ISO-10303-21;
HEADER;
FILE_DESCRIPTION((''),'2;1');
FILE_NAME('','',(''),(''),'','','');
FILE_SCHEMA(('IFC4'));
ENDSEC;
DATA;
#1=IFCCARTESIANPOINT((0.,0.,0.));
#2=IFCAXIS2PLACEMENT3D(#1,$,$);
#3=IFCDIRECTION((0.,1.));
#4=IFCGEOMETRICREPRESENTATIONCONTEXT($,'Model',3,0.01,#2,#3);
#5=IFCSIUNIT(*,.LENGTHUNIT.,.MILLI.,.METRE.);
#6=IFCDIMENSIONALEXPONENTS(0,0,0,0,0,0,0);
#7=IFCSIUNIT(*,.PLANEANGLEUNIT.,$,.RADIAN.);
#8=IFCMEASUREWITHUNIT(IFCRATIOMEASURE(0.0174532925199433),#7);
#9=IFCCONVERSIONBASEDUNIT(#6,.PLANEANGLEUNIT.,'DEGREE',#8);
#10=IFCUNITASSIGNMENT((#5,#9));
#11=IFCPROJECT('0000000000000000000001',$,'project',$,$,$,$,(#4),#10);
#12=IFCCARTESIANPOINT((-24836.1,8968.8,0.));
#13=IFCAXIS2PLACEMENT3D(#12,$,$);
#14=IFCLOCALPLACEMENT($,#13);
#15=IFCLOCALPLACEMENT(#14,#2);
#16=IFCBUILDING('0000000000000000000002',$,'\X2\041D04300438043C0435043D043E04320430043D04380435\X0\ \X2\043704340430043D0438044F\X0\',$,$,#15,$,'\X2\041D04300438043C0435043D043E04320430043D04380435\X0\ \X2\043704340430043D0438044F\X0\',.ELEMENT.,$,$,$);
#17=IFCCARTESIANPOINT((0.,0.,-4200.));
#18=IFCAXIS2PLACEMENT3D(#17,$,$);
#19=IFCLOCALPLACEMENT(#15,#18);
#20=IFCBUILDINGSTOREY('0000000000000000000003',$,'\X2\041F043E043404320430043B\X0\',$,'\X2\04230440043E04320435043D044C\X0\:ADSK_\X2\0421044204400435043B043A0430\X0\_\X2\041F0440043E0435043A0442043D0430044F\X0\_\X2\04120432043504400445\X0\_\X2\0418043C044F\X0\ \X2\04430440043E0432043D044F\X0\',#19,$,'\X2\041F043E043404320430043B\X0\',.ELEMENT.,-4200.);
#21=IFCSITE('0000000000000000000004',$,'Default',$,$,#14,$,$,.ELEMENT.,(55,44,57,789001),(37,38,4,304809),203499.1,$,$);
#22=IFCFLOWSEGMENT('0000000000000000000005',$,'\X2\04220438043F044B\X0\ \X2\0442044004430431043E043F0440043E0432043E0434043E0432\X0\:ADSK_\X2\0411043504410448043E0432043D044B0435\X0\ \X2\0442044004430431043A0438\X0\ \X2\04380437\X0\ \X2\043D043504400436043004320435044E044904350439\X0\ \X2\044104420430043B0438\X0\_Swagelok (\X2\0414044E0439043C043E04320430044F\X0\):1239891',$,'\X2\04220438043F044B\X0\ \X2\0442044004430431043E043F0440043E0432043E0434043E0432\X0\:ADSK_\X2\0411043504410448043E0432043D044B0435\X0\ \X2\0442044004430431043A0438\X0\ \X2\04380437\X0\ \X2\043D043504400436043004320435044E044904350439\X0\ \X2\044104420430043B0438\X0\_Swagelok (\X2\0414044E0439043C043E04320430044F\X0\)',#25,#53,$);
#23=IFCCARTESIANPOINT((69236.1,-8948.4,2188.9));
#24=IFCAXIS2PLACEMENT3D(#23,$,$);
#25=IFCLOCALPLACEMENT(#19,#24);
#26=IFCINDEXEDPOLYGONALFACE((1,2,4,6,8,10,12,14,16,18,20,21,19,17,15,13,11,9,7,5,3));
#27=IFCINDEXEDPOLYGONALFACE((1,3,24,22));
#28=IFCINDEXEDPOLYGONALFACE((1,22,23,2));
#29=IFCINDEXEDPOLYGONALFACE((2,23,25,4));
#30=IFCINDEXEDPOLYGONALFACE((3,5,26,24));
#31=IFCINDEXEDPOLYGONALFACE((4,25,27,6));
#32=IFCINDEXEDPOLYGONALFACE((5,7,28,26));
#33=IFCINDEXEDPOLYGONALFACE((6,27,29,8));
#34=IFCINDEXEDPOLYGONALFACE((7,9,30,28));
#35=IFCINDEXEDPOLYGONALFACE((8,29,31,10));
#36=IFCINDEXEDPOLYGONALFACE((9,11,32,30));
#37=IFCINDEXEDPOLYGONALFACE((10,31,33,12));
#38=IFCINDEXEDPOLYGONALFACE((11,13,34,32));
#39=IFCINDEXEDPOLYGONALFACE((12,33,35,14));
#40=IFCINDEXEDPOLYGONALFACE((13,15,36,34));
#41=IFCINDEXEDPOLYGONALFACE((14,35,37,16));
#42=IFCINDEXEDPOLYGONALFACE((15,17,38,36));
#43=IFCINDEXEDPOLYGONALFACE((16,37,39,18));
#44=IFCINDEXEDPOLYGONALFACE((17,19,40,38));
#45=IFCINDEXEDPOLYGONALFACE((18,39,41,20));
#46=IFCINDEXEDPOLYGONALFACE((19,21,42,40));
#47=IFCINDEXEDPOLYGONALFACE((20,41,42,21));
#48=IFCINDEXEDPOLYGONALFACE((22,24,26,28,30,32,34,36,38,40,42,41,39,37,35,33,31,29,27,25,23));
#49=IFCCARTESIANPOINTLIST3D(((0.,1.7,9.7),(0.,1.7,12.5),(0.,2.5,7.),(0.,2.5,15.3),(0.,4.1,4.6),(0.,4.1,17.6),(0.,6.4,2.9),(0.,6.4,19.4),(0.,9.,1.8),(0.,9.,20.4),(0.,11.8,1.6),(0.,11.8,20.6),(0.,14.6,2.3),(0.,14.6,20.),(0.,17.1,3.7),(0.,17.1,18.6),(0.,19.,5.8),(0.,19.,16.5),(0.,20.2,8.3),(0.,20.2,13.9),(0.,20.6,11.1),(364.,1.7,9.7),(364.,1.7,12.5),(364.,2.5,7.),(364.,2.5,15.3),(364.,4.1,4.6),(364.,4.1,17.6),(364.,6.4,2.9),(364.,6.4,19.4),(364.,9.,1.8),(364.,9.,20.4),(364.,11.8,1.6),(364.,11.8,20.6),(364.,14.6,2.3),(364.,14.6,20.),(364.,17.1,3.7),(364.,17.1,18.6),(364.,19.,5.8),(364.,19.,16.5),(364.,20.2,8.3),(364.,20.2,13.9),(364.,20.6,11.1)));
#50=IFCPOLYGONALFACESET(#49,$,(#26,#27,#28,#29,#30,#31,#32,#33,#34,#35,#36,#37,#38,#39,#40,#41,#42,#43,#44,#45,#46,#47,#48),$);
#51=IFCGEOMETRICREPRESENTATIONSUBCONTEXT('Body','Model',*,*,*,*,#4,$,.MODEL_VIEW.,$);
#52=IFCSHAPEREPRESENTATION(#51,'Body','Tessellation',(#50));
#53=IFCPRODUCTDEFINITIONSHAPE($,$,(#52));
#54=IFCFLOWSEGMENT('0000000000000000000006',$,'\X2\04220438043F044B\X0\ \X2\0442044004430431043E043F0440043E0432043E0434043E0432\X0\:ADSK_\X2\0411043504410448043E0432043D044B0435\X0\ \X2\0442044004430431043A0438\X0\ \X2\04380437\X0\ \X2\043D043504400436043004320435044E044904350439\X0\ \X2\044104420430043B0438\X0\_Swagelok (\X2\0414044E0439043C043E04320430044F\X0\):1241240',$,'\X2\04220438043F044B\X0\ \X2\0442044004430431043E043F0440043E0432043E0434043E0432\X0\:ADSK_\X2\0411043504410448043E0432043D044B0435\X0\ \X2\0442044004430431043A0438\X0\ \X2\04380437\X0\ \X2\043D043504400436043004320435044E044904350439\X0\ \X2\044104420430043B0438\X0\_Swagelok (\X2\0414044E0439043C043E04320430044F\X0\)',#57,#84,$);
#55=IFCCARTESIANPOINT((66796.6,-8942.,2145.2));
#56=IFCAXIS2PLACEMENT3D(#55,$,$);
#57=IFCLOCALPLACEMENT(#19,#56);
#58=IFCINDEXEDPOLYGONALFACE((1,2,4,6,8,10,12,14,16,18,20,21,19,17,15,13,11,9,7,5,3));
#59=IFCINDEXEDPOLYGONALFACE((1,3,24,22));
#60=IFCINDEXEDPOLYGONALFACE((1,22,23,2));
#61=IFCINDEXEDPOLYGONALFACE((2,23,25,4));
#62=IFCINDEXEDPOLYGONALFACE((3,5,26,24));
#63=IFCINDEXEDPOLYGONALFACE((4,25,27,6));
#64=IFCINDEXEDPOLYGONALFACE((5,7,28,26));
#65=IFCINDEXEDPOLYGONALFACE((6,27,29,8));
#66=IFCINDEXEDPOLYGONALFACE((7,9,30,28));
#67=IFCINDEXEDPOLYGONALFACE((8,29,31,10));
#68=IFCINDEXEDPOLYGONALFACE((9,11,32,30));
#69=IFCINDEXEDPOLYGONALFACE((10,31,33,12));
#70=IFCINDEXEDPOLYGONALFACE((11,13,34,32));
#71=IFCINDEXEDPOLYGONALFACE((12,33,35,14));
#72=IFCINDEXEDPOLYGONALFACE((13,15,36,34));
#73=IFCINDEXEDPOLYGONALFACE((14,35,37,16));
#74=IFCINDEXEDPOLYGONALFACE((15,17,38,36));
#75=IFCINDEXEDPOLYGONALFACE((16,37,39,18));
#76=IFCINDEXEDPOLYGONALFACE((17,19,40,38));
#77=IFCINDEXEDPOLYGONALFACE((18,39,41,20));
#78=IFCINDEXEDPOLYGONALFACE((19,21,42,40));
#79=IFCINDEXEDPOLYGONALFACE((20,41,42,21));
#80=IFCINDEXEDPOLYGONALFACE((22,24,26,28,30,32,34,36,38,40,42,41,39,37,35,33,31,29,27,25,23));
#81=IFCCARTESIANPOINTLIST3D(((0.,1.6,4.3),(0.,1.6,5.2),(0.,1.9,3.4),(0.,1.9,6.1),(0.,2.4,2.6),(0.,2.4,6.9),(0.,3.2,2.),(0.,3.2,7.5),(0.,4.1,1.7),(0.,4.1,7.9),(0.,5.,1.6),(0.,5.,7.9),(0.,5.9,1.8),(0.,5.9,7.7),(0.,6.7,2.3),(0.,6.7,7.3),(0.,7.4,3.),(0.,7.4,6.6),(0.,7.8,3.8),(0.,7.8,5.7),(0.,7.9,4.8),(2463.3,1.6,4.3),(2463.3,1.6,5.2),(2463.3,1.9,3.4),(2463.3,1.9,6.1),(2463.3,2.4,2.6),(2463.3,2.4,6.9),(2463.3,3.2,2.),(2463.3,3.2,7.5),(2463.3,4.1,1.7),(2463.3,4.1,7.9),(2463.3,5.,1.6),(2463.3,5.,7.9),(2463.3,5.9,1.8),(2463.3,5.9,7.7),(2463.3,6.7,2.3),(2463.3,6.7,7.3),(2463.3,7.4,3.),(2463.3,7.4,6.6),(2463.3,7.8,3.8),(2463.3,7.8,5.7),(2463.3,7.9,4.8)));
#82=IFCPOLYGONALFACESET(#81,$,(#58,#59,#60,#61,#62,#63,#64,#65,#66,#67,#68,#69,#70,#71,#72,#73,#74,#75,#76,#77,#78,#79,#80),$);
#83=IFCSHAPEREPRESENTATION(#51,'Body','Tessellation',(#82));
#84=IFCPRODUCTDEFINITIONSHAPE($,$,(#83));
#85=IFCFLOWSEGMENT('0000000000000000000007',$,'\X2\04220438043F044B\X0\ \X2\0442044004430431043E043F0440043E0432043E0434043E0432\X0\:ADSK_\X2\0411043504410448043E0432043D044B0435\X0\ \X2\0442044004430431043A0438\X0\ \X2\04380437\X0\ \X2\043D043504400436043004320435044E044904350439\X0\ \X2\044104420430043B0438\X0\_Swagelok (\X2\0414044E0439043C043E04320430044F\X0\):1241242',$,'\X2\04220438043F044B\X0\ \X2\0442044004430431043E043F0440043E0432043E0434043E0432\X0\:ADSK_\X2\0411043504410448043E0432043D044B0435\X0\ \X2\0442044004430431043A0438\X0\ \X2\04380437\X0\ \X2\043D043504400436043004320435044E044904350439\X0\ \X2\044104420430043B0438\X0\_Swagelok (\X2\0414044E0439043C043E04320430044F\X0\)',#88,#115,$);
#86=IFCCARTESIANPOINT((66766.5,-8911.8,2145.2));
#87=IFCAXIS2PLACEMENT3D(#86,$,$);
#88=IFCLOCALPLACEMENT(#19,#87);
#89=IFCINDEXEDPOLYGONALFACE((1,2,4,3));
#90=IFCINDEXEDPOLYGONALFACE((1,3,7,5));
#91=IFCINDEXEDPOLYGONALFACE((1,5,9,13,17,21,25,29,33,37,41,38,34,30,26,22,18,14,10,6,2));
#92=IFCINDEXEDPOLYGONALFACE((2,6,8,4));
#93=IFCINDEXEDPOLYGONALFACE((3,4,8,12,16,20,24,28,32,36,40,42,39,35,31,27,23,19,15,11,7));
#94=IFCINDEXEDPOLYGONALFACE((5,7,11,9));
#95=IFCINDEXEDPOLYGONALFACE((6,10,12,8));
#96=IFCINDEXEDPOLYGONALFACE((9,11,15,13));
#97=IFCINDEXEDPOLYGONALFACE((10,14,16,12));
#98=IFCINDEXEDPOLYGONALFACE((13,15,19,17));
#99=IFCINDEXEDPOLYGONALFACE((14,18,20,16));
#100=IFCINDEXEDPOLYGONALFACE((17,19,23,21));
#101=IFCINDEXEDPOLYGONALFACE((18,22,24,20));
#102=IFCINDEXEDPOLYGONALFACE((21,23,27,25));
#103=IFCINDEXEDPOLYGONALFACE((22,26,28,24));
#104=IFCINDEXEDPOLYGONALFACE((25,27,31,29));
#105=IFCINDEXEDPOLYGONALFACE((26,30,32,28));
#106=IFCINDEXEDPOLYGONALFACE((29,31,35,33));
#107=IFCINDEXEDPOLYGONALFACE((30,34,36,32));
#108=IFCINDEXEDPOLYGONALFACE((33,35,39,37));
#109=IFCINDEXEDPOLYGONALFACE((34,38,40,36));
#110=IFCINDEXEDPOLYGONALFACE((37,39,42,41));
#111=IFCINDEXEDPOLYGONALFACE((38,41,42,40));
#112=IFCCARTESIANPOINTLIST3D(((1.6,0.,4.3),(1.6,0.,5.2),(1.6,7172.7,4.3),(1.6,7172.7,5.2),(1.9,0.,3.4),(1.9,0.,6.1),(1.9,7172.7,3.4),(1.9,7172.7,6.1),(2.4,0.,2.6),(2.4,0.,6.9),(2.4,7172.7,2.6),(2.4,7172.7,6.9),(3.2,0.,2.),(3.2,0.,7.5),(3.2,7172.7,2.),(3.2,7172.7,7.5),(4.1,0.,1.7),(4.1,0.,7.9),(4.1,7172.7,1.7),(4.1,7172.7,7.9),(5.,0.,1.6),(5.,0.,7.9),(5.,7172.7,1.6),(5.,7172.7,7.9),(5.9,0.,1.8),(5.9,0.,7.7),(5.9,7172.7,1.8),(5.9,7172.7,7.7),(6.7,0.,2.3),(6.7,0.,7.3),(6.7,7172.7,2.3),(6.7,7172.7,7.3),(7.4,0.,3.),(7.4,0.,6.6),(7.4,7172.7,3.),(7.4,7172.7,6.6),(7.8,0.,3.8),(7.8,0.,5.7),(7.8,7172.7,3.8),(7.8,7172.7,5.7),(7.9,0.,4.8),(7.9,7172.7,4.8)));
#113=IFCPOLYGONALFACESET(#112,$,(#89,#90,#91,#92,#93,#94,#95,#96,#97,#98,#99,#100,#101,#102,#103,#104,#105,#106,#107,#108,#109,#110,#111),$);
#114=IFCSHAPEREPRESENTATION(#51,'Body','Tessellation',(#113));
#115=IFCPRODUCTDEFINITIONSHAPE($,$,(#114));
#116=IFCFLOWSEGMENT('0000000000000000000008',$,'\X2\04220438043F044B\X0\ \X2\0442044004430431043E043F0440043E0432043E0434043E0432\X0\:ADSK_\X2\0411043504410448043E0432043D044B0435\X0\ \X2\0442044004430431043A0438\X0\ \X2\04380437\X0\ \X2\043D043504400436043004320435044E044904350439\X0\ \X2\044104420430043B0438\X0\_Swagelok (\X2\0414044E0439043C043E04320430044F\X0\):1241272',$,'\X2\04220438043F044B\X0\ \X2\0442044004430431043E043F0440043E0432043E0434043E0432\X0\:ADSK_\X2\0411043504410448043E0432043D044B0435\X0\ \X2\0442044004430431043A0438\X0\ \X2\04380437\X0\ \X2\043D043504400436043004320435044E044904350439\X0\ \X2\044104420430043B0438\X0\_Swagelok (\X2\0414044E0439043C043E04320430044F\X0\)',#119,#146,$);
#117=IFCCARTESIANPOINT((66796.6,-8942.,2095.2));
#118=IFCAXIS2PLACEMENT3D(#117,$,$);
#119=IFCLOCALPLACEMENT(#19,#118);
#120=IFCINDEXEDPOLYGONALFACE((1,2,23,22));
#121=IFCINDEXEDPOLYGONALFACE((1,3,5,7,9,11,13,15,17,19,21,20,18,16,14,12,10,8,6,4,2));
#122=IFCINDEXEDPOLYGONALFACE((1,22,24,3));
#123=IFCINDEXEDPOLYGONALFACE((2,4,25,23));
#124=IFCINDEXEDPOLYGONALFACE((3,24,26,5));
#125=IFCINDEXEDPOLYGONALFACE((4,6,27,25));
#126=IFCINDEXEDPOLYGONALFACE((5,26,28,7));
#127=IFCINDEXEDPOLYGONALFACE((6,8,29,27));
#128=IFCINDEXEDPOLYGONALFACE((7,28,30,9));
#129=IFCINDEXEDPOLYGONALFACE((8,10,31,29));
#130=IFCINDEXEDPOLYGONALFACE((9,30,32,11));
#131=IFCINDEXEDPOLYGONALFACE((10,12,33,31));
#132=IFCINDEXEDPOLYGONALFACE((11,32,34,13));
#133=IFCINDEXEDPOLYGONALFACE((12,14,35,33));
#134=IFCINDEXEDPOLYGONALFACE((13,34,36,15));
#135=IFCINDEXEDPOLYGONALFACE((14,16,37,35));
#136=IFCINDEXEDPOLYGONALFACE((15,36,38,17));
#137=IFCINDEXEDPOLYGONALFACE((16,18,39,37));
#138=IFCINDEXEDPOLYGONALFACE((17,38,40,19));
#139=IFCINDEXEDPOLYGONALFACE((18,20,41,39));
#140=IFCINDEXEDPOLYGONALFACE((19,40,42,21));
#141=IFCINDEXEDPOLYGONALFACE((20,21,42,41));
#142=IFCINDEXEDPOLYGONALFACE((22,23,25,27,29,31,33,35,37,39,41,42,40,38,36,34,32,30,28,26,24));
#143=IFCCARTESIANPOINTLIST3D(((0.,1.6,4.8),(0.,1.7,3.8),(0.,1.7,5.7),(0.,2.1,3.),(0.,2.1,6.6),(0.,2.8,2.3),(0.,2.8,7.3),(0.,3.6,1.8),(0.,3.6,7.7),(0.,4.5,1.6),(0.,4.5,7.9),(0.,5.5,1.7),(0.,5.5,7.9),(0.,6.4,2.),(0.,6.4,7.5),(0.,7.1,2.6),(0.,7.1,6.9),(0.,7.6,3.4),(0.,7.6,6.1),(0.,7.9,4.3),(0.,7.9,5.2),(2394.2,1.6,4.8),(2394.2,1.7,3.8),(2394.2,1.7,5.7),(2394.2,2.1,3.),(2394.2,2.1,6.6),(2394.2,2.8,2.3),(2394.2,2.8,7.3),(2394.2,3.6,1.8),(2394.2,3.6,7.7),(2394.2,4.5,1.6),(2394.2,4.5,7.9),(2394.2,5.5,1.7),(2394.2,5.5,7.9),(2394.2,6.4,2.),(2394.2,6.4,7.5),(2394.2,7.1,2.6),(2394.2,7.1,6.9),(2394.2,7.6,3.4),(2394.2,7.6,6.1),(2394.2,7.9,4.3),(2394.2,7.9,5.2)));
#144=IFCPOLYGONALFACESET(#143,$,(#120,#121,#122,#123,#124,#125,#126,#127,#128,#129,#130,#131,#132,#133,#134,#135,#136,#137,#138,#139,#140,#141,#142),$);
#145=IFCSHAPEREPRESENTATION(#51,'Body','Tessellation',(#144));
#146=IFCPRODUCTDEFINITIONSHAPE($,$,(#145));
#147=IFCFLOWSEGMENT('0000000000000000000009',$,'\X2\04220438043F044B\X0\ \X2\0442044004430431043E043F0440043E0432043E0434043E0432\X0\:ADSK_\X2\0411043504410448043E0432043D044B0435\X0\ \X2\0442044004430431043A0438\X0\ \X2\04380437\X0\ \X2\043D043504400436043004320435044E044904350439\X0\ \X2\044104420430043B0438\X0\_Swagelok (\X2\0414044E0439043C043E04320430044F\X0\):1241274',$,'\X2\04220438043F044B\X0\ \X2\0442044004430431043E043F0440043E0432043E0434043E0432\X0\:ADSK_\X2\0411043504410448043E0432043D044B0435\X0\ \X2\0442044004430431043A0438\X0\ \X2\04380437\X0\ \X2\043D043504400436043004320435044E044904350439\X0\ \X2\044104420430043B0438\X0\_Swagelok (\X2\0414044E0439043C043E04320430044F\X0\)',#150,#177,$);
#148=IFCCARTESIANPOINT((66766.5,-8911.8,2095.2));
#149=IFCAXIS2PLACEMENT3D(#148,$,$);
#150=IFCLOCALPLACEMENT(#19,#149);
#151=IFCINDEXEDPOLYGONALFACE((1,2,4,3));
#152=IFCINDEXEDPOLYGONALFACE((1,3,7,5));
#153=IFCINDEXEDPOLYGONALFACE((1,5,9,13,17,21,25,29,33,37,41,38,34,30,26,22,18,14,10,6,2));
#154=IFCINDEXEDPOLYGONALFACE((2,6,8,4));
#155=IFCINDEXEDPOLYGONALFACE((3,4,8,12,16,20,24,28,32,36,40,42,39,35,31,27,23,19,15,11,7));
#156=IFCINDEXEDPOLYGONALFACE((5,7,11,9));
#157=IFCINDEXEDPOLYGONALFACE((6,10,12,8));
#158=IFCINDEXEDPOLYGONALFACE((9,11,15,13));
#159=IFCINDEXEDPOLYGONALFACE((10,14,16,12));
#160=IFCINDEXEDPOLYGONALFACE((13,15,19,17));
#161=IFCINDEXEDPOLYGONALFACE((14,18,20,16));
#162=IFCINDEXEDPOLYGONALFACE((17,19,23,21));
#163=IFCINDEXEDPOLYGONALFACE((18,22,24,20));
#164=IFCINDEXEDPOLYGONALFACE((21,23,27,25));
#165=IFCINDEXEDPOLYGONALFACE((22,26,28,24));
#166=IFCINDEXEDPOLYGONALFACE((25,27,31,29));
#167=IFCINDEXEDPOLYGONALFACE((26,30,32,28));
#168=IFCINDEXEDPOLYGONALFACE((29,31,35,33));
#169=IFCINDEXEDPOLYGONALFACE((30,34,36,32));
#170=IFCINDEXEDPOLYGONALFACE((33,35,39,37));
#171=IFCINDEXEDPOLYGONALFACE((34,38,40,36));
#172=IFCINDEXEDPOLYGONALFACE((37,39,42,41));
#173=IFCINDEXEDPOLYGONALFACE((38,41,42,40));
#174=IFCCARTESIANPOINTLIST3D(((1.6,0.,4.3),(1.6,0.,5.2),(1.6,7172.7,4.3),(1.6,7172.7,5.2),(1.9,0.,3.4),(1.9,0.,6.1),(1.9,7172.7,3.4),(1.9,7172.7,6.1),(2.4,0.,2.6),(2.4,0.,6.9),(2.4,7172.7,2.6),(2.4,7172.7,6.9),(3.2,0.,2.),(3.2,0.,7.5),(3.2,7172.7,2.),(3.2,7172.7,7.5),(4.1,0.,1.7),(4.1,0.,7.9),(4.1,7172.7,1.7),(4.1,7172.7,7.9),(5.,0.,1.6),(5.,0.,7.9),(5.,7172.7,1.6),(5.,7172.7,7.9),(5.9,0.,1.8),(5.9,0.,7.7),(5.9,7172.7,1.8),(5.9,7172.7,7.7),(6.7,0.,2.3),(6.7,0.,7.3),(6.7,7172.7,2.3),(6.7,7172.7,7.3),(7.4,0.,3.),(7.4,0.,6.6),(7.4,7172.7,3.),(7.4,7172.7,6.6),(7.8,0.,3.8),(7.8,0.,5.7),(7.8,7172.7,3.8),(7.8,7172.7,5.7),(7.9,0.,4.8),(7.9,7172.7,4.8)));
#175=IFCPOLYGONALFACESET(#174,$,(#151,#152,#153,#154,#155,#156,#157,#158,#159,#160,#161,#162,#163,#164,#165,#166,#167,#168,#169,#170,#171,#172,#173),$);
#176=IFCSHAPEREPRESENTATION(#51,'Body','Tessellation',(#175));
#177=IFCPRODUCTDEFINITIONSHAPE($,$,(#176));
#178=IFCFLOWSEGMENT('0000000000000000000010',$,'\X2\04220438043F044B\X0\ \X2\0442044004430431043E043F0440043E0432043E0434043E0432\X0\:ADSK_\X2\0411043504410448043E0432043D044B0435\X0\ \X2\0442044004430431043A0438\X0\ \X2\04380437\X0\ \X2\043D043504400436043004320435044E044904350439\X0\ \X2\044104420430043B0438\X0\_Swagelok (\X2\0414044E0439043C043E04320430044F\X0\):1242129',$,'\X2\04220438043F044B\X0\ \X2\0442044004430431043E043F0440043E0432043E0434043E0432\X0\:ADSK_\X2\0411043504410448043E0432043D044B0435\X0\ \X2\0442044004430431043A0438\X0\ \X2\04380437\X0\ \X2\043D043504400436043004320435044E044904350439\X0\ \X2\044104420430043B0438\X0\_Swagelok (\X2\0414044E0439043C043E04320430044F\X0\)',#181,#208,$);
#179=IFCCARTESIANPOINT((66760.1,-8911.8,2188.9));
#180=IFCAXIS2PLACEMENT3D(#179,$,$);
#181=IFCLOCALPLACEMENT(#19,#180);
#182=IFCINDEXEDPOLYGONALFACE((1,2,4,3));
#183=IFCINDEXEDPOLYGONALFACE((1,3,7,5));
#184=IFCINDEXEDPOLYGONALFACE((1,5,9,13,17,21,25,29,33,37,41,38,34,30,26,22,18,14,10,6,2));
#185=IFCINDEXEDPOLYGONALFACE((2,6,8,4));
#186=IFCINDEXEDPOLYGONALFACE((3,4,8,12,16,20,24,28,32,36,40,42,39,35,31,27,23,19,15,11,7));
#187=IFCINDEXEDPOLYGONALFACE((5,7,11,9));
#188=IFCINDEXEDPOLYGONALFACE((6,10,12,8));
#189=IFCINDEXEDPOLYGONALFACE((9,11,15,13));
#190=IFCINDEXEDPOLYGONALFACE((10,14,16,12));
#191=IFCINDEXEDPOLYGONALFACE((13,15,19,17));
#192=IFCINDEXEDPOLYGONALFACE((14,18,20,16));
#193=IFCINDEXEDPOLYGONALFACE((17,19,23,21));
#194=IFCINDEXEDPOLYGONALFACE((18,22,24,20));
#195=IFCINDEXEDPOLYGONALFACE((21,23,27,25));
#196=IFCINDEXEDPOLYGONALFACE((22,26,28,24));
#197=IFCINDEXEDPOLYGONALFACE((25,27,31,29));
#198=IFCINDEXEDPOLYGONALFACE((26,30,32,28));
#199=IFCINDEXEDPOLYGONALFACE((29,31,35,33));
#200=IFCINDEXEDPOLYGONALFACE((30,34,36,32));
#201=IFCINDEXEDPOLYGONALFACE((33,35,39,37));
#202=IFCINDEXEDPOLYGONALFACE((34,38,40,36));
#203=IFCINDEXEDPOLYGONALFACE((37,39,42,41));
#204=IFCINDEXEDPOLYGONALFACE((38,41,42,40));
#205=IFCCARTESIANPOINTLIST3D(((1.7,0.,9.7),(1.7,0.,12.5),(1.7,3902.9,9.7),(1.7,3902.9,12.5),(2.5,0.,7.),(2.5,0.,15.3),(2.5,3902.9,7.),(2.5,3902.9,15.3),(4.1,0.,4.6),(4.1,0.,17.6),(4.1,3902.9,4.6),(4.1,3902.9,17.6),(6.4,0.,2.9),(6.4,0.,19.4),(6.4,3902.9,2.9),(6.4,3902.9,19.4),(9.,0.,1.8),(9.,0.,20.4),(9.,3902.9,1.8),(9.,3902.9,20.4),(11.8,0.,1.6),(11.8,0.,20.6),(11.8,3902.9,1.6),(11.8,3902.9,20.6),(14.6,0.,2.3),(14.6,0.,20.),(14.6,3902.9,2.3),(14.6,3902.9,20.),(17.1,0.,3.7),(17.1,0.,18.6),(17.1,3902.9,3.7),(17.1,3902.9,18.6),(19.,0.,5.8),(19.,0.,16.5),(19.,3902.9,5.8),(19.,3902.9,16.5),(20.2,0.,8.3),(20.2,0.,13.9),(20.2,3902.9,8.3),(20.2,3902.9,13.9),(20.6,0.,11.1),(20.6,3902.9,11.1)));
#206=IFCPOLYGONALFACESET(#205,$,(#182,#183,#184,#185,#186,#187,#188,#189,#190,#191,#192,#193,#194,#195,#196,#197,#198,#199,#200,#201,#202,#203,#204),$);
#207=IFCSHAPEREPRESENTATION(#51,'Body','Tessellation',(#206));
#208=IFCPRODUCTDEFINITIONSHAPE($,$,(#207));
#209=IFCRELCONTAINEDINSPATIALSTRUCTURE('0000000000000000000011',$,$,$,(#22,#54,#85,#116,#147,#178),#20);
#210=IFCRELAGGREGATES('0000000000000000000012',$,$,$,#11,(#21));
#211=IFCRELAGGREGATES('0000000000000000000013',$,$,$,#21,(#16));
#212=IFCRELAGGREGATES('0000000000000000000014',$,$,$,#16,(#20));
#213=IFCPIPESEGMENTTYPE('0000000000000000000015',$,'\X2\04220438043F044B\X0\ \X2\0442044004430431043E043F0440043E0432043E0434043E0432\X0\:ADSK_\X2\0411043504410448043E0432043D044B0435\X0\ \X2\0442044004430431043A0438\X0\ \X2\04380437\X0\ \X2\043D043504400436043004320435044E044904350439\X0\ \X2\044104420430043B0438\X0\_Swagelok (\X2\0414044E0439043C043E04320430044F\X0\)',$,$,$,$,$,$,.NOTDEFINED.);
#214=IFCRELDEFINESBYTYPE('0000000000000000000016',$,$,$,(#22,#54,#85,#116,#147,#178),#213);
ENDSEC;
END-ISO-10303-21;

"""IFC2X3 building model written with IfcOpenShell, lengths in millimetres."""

from ifc_helpers import new_model, entity, si_unit, converted_unit, direction, frame, origin, origin_2d_with_axis, place, context, subcontext, project, spatial, circle, extrude, type_object, element, save


model = new_model("IFC2X3")

# Units and contexts
model_context = context("Model", 3, precision=0.01, world=origin(), true_north=direction((0.0, 1.0)))
body_context = subcontext(model_context, "Body", "Model", "MODEL_VIEW")
ifc_project = project(units=[si_unit("LENGTHUNIT", "METRE", prefix="MILLI"), converted_unit("PLANEANGLEUNIT", "DEGREE", entity("IfcRatioMeasure", 0.0174532925199433), si_unit("PLANEANGLEUNIT", "RADIAN"), dimensions=[0, 0, 0, 0, 0, 0, 0])], contexts=[model_context])

# Site, building, storey
site_placement = place(None, frame((-24836.1, 8968.8, 0.0)))
site = spatial("IfcSite", under=ifc_project, at=site_placement, Name="Default", CompositionType="ELEMENT", RefLatitude=(55, 44, 57, 789001), RefLongitude=(37, 38, 4, 304809), RefElevation=203499.1)
building_placement = place(site_placement, origin())
building = spatial("IfcBuilding", under=site, at=building_placement, Name="Наименование здания", LongName="Наименование здания", CompositionType="ELEMENT")
storey_placement = place(building_placement, frame((0.0, 0.0, -4200.0)))
storey = spatial("IfcBuildingStorey", under=building, at=storey_placement, Name="Подвал", ObjectType="Уровень:ADSK_Стрелка_Проектная_Вверх_Имя уровня", LongName="Подвал", CompositionType="ELEMENT", Elevation=-4200.0)

# Flow segments
pipe_segment_type = type_object("IfcPipeSegmentType", Name="Типы трубопроводов:ADSK_Бесшовные трубки из нержавеющей стали_Swagelok (Дюймовая)", PredefinedType="NOTDEFINED")
flow_segment_1_placement = place(storey_placement, frame((69236.1, -8948.4, 2188.9)))
element("IfcFlowSegment", 1, at=flow_segment_1_placement, inside=storey, type_object=pipe_segment_type, Name="Типы трубопроводов:ADSK_Бесшовные трубки из нержавеющей стали_Swagelok (Дюймовая):1239891", ObjectType="Типы трубопроводов:ADSK_Бесшовные трубки из нержавеющей стали_Swagelok (Дюймовая)", context=body_context, shape_type="SweptSolid", body=[
    extrude(circle(Radius=9.5, at=origin_2d_with_axis()), frame((0.0, 11.1, 11.1), z_axis=(1.0, 0.0, 0.0), x_axis=(0.0, 1.0, 0.0)), (0.0, 0.0, 1.0), 364.0),
])
flow_segment_2_placement = place(storey_placement, frame((66796.6, -8942.0, 2145.2)))
element("IfcFlowSegment", 2, at=flow_segment_2_placement, inside=storey, type_object=pipe_segment_type, Name="Типы трубопроводов:ADSK_Бесшовные трубки из нержавеющей стали_Swagelok (Дюймовая):1241240", ObjectType="Типы трубопроводов:ADSK_Бесшовные трубки из нержавеющей стали_Swagelok (Дюймовая)", context=body_context, shape_type="SweptSolid", body=[
    extrude(circle(Radius=3.2, at=origin_2d_with_axis()), frame((0.0, 4.8, 4.8), z_axis=(1.0, 0.0, 0.0), x_axis=(0.0, 1.0, 0.0)), (0.0, 0.0, 1.0), 2463.3),
])
flow_segment_3_placement = place(storey_placement, frame((66766.5, -8911.8, 2145.2)))
element("IfcFlowSegment", 3, at=flow_segment_3_placement, inside=storey, type_object=pipe_segment_type, Name="Типы трубопроводов:ADSK_Бесшовные трубки из нержавеющей стали_Swagelok (Дюймовая):1241242", ObjectType="Типы трубопроводов:ADSK_Бесшовные трубки из нержавеющей стали_Swagelok (Дюймовая)", context=body_context, shape_type="SweptSolid", body=[
    extrude(circle(Radius=3.2, at=origin_2d_with_axis()), frame((4.8, 0.0, 4.8), z_axis=(0.0, 1.0, 0.0), x_axis=(1.0, 0.0, 0.0)), (0.0, 0.0, 1.0), 7172.7),
])
flow_segment_4_placement = place(storey_placement, frame((66796.6, -8942.0, 2095.2)))
element("IfcFlowSegment", 4, at=flow_segment_4_placement, inside=storey, type_object=pipe_segment_type, Name="Типы трубопроводов:ADSK_Бесшовные трубки из нержавеющей стали_Swagelok (Дюймовая):1241272", ObjectType="Типы трубопроводов:ADSK_Бесшовные трубки из нержавеющей стали_Swagelok (Дюймовая)", context=body_context, shape_type="SweptSolid", body=[
    extrude(circle(Radius=3.2, at=origin_2d_with_axis()), frame((0.0, 4.8, 4.8), z_axis=(1.0, 0.0, 0.0), x_axis=(0.0, -1.0, 0.0)), (0.0, 0.0, 1.0), 2394.2),
])
flow_segment_5_placement = place(storey_placement, frame((66766.5, -8911.8, 2095.2)))
element("IfcFlowSegment", 5, at=flow_segment_5_placement, inside=storey, type_object=pipe_segment_type, Name="Типы трубопроводов:ADSK_Бесшовные трубки из нержавеющей стали_Swagelok (Дюймовая):1241274", ObjectType="Типы трубопроводов:ADSK_Бесшовные трубки из нержавеющей стали_Swagelok (Дюймовая)", context=body_context, shape_type="SweptSolid", body=[
    extrude(circle(Radius=3.2, at=origin_2d_with_axis()), frame((4.8, 0.0, 4.8), z_axis=(0.0, 1.0, 0.0), x_axis=(1.0, 0.0, 0.0)), (0.0, 0.0, 1.0), 7172.7),
])
flow_segment_6_placement = place(storey_placement, frame((66760.1, -8911.8, 2188.9)))
element("IfcFlowSegment", 6, at=flow_segment_6_placement, inside=storey, type_object=pipe_segment_type, Name="Типы трубопроводов:ADSK_Бесшовные трубки из нержавеющей стали_Swagelok (Дюймовая):1242129", ObjectType="Типы трубопроводов:ADSK_Бесшовные трубки из нержавеющей стали_Swagelok (Дюймовая)", context=body_context, shape_type="SweptSolid", body=[
    extrude(circle(Radius=9.5, at=origin_2d_with_axis()), frame((11.1, 0.0, 11.1), z_axis=(0.0, 1.0, 0.0), x_axis=(1.0, 0.0, 0.0)), (0.0, 0.0, 1.0), 3902.9),
])

save(model, "model.ifc")
